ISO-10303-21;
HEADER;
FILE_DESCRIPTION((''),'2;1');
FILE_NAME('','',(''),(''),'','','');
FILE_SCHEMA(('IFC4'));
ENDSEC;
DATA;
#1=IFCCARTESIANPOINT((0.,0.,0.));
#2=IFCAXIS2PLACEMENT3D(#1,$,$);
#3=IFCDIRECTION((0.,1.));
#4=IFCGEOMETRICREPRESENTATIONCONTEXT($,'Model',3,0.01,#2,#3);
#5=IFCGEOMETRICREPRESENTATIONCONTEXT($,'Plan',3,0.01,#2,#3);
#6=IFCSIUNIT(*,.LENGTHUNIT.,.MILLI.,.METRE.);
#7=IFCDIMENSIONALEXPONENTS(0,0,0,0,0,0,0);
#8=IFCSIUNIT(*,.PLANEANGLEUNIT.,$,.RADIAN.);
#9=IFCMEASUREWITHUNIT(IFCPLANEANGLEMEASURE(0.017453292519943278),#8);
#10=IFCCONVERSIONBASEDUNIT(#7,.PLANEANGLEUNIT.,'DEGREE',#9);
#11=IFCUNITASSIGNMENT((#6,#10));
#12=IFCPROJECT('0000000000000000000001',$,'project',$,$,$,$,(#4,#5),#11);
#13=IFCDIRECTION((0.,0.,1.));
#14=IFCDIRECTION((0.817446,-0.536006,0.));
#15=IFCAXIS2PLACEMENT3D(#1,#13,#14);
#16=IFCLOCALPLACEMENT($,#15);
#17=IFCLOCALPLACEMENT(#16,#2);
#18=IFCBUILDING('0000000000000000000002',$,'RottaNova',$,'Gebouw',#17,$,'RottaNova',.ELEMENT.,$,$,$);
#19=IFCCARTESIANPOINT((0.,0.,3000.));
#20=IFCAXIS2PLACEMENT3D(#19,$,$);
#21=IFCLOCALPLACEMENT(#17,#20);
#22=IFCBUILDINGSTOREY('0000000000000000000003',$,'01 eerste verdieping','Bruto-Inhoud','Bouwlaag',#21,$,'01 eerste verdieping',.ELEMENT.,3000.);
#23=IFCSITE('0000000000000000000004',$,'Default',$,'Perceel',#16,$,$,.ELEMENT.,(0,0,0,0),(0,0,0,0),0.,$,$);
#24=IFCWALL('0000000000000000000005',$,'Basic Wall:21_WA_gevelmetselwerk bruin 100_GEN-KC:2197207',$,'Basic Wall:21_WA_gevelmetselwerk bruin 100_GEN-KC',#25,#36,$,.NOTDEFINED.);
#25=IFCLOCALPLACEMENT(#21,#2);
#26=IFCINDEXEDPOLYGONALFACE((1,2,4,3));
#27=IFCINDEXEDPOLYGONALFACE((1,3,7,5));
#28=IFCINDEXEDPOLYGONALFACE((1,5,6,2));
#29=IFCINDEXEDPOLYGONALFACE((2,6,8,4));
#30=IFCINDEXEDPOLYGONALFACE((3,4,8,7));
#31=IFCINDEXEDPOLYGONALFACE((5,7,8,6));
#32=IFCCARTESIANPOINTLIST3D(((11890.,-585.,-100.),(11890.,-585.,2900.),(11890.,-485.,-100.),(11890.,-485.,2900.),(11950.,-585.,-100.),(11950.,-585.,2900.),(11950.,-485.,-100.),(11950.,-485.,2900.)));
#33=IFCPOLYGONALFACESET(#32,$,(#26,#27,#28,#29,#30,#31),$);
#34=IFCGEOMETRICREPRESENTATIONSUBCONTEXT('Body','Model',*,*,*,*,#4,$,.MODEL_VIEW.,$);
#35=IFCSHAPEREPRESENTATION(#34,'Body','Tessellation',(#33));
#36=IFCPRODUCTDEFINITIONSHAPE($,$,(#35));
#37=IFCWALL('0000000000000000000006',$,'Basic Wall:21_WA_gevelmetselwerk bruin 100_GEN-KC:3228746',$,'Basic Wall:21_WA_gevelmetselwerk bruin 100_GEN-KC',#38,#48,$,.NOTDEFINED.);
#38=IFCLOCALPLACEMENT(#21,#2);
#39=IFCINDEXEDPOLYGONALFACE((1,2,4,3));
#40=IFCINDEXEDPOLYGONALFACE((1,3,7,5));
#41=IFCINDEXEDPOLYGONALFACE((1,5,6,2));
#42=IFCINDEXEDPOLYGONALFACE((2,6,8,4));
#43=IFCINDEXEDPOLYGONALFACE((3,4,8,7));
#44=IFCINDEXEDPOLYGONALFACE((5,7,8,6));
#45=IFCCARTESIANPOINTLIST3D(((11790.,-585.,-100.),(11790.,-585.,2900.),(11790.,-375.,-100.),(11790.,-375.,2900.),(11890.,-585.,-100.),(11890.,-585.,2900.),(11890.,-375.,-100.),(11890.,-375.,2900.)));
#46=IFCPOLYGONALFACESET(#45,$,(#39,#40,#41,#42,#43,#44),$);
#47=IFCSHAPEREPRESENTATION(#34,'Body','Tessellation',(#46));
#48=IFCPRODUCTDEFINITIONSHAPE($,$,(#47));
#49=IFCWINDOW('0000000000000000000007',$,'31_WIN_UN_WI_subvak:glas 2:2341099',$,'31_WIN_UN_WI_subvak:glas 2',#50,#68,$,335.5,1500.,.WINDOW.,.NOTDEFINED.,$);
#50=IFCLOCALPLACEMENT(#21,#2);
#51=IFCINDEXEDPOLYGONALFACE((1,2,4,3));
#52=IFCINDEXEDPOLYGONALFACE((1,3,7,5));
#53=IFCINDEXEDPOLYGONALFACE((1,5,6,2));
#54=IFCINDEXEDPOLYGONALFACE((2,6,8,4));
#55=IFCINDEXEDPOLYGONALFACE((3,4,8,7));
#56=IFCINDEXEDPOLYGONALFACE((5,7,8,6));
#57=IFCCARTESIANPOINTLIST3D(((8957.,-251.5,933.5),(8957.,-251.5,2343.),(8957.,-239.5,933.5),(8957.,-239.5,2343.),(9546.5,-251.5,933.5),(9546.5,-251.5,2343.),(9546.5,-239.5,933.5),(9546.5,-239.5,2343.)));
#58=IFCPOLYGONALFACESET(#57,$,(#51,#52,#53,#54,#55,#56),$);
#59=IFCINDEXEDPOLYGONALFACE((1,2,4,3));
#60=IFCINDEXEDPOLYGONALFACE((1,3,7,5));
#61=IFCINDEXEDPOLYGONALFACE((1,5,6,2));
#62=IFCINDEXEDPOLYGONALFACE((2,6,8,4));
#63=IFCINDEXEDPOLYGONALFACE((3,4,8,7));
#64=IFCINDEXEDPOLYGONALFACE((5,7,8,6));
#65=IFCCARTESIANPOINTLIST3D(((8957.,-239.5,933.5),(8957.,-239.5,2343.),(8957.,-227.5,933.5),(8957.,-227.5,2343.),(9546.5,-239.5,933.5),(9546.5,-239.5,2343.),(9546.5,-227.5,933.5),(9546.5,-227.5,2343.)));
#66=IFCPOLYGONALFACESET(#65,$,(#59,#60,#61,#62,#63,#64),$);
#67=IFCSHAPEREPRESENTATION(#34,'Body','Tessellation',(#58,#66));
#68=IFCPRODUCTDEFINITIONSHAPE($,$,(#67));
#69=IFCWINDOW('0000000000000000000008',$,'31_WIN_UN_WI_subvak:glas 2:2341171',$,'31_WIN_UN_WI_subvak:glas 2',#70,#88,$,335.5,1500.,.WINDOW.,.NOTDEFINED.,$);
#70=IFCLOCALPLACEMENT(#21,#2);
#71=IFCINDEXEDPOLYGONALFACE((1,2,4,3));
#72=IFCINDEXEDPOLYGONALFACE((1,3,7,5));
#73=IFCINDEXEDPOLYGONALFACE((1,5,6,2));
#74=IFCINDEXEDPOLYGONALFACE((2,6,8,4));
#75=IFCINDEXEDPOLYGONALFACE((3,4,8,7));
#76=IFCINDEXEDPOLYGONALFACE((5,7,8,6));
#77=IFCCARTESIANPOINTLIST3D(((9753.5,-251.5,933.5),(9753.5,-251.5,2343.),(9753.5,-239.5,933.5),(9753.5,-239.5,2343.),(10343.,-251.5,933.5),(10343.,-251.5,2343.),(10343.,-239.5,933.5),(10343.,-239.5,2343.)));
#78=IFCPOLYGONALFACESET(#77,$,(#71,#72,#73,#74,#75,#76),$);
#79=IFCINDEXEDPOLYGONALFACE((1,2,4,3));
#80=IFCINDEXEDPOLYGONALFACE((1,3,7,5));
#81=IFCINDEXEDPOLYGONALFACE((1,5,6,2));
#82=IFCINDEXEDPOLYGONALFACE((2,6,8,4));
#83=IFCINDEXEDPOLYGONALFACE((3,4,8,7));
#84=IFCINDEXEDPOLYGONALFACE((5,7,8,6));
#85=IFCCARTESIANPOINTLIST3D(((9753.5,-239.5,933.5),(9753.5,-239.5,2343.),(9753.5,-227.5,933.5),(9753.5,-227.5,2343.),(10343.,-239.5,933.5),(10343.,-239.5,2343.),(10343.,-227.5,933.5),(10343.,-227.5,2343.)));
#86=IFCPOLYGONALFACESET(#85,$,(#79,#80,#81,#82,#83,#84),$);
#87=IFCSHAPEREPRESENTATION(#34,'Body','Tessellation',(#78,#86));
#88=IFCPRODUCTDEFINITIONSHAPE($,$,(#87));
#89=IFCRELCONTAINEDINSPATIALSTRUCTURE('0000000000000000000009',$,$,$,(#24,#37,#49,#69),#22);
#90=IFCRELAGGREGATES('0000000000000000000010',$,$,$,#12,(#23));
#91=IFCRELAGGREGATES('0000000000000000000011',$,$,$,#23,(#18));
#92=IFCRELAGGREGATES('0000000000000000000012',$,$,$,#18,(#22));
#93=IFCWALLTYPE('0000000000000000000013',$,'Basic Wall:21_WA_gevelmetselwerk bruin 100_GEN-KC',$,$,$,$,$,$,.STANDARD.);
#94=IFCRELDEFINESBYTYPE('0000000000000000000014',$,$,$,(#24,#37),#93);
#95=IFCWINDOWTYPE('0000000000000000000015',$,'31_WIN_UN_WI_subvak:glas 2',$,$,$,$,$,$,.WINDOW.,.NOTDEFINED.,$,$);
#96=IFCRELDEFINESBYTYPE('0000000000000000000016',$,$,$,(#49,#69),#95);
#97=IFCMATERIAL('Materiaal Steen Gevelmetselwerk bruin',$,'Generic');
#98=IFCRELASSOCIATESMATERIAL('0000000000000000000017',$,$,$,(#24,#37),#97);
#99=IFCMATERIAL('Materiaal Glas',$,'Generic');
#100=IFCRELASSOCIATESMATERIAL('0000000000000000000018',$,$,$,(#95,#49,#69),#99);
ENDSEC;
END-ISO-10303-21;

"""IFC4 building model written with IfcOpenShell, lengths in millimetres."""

from ifc_helpers import new_model, entity, si_unit, converted_unit, direction, frame, origin, place, context, subcontext, project, spatial, indexed_curve, outline, extrude, source, transform, mapped, material, type_object, type_shapes, element, save


model = new_model("IFC4")

# Units and contexts
model_context = context("Model", 3, precision=0.01, world=origin(), true_north=direction((0.0, 1.0)))
plan_context = context("Plan", 3, precision=0.01, world=origin(), true_north=direction((0.0, 1.0)))
body_context = subcontext(model_context, "Body", "Model", "MODEL_VIEW")
ifc_project = project(units=[si_unit("LENGTHUNIT", "METRE", prefix="MILLI"), converted_unit("PLANEANGLEUNIT", "DEGREE", entity("IfcPlaneAngleMeasure", 0.017453292519943278), si_unit("PLANEANGLEUNIT", "RADIAN"), dimensions=[0, 0, 0, 0, 0, 0, 0])], contexts=[model_context, plan_context])

# Site, building, storey
site_placement = place(None, frame((0.0, 0.0, 0.0), z_axis=(0.0, 0.0, 1.0), x_axis=(0.817446, -0.536006, 0.0)))
site = spatial("IfcSite", under=ifc_project, at=site_placement, Name="Default", ObjectType="Perceel", CompositionType="ELEMENT", RefLatitude=(0, 0, 0, 0), RefLongitude=(0, 0, 0, 0), RefElevation=0.0)
building_placement = place(site_placement, origin())
building = spatial("IfcBuilding", under=site, at=building_placement, Name="RottaNova", ObjectType="Gebouw", LongName="RottaNova", CompositionType="ELEMENT")
storey_placement = place(building_placement, frame((0.0, 0.0, 3000.0)))
storey = spatial("IfcBuildingStorey", under=building, at=storey_placement, Name="01 eerste verdieping", Description="Bruto-Inhoud", ObjectType="Bouwlaag", LongName="01 eerste verdieping", CompositionType="ELEMENT", Elevation=3000.0)

# Shared definitions
ifc_material_1 = material(Name="Materiaal Glas", Category="Generic")

# Walls
ifc_material_2 = material(Name="Materiaal Steen Gevelmetselwerk bruin", Category="Generic")
wall_type_1 = type_object("IfcWallType", Name="Basic Wall:21_WA_gevelmetselwerk bruin 100_GEN-KC", PredefinedType="STANDARD")
wall_1_placement = place(storey_placement, frame((11890.0, -535.0, -100.0)))
element("IfcWall", 1, at=wall_1_placement, inside=storey, type_object=wall_type_1, material=ifc_material_2, Name="Basic Wall:21_WA_gevelmetselwerk bruin 100_GEN-KC:2197207", ObjectType="Basic Wall:21_WA_gevelmetselwerk bruin 100_GEN-KC", PredefinedType="NOTDEFINED", context=body_context, shape_type="SweptSolid", body=[
    extrude(outline(indexed_curve([(60.0, 50.0), (0.0, 50.0), (0.0, -50.0), (60.0, -50.0), (60.0, 50.0)], self_intersect=False)), origin(), (0.0, 0.0, 1.0), 3000.0),
])
wall_2_placement = place(storey_placement, frame((11840.0, -585.0, -100.0), z_axis=(0.0, 0.0, 1.0), x_axis=(0.0, 1.0, 0.0)))
element("IfcWall", 2, at=wall_2_placement, inside=storey, type_object=wall_type_1, material=ifc_material_2, Name="Basic Wall:21_WA_gevelmetselwerk bruin 100_GEN-KC:3228746", ObjectType="Basic Wall:21_WA_gevelmetselwerk bruin 100_GEN-KC", PredefinedType="NOTDEFINED", context=body_context, shape_type="SweptSolid", body=[
    extrude(outline(indexed_curve([(210.0, 50.0), (0.0, 50.0), (0.0, -50.0), (210.0, -50.0), (210.0, 50.0)], self_intersect=False)), origin(), (0.0, 0.0, 1.0), 3000.0),
])

# Windows
window_type = type_object("IfcWindowType", Name="31_WIN_UN_WI_subvak:glas 2", PartitioningType="NOTDEFINED", PredefinedType="WINDOW", material=ifc_material_1)
shared_shape_1 = source(origin(), body_context, "Body", "SweptSolid", [
    extrude(outline(indexed_curve([(-294.7, -6.0), (294.7, -6.0), (294.7, 6.0), (-294.7, 6.0), (-294.7, -6.0)], self_intersect=False)), frame((0.0, -6.0, 0.0)), (0.0, 0.0, 1.0), 1409.5),
    extrude(outline(indexed_curve([(-294.8, -6.0), (294.8, -6.0), (294.8, 6.0), (-294.8, 6.0), (-294.8, -6.0)], self_intersect=False)), frame((0.0, 6.0, 0.0)), (0.0, 0.0, 1.0), 1409.5),
])
type_shapes(window_type, [shared_shape_1])
for number, where, name in (
    (3, (9251.7, -239.5, 933.5), "31_WIN_UN_WI_subvak:glas 2:2341099"),
    (4, (10048.2, -239.5, 933.5), "31_WIN_UN_WI_subvak:glas 2:2341171"),
):
    element("IfcWindow", number, at=place(storey_placement, frame(where)), inside=storey, type_object=window_type, material=ifc_material_1, Name=name, ObjectType="31_WIN_UN_WI_subvak:glas 2", OverallHeight=335.5, OverallWidth=1500.0, PartitioningType="NOTDEFINED", PredefinedType="WINDOW", context=body_context, shape_type="MappedRepresentation", body=[
        mapped(shared_shape_1, transform((0.0, 0.0, 0.0), scale=1.0)),
    ])

save(model, "model.ifc")
